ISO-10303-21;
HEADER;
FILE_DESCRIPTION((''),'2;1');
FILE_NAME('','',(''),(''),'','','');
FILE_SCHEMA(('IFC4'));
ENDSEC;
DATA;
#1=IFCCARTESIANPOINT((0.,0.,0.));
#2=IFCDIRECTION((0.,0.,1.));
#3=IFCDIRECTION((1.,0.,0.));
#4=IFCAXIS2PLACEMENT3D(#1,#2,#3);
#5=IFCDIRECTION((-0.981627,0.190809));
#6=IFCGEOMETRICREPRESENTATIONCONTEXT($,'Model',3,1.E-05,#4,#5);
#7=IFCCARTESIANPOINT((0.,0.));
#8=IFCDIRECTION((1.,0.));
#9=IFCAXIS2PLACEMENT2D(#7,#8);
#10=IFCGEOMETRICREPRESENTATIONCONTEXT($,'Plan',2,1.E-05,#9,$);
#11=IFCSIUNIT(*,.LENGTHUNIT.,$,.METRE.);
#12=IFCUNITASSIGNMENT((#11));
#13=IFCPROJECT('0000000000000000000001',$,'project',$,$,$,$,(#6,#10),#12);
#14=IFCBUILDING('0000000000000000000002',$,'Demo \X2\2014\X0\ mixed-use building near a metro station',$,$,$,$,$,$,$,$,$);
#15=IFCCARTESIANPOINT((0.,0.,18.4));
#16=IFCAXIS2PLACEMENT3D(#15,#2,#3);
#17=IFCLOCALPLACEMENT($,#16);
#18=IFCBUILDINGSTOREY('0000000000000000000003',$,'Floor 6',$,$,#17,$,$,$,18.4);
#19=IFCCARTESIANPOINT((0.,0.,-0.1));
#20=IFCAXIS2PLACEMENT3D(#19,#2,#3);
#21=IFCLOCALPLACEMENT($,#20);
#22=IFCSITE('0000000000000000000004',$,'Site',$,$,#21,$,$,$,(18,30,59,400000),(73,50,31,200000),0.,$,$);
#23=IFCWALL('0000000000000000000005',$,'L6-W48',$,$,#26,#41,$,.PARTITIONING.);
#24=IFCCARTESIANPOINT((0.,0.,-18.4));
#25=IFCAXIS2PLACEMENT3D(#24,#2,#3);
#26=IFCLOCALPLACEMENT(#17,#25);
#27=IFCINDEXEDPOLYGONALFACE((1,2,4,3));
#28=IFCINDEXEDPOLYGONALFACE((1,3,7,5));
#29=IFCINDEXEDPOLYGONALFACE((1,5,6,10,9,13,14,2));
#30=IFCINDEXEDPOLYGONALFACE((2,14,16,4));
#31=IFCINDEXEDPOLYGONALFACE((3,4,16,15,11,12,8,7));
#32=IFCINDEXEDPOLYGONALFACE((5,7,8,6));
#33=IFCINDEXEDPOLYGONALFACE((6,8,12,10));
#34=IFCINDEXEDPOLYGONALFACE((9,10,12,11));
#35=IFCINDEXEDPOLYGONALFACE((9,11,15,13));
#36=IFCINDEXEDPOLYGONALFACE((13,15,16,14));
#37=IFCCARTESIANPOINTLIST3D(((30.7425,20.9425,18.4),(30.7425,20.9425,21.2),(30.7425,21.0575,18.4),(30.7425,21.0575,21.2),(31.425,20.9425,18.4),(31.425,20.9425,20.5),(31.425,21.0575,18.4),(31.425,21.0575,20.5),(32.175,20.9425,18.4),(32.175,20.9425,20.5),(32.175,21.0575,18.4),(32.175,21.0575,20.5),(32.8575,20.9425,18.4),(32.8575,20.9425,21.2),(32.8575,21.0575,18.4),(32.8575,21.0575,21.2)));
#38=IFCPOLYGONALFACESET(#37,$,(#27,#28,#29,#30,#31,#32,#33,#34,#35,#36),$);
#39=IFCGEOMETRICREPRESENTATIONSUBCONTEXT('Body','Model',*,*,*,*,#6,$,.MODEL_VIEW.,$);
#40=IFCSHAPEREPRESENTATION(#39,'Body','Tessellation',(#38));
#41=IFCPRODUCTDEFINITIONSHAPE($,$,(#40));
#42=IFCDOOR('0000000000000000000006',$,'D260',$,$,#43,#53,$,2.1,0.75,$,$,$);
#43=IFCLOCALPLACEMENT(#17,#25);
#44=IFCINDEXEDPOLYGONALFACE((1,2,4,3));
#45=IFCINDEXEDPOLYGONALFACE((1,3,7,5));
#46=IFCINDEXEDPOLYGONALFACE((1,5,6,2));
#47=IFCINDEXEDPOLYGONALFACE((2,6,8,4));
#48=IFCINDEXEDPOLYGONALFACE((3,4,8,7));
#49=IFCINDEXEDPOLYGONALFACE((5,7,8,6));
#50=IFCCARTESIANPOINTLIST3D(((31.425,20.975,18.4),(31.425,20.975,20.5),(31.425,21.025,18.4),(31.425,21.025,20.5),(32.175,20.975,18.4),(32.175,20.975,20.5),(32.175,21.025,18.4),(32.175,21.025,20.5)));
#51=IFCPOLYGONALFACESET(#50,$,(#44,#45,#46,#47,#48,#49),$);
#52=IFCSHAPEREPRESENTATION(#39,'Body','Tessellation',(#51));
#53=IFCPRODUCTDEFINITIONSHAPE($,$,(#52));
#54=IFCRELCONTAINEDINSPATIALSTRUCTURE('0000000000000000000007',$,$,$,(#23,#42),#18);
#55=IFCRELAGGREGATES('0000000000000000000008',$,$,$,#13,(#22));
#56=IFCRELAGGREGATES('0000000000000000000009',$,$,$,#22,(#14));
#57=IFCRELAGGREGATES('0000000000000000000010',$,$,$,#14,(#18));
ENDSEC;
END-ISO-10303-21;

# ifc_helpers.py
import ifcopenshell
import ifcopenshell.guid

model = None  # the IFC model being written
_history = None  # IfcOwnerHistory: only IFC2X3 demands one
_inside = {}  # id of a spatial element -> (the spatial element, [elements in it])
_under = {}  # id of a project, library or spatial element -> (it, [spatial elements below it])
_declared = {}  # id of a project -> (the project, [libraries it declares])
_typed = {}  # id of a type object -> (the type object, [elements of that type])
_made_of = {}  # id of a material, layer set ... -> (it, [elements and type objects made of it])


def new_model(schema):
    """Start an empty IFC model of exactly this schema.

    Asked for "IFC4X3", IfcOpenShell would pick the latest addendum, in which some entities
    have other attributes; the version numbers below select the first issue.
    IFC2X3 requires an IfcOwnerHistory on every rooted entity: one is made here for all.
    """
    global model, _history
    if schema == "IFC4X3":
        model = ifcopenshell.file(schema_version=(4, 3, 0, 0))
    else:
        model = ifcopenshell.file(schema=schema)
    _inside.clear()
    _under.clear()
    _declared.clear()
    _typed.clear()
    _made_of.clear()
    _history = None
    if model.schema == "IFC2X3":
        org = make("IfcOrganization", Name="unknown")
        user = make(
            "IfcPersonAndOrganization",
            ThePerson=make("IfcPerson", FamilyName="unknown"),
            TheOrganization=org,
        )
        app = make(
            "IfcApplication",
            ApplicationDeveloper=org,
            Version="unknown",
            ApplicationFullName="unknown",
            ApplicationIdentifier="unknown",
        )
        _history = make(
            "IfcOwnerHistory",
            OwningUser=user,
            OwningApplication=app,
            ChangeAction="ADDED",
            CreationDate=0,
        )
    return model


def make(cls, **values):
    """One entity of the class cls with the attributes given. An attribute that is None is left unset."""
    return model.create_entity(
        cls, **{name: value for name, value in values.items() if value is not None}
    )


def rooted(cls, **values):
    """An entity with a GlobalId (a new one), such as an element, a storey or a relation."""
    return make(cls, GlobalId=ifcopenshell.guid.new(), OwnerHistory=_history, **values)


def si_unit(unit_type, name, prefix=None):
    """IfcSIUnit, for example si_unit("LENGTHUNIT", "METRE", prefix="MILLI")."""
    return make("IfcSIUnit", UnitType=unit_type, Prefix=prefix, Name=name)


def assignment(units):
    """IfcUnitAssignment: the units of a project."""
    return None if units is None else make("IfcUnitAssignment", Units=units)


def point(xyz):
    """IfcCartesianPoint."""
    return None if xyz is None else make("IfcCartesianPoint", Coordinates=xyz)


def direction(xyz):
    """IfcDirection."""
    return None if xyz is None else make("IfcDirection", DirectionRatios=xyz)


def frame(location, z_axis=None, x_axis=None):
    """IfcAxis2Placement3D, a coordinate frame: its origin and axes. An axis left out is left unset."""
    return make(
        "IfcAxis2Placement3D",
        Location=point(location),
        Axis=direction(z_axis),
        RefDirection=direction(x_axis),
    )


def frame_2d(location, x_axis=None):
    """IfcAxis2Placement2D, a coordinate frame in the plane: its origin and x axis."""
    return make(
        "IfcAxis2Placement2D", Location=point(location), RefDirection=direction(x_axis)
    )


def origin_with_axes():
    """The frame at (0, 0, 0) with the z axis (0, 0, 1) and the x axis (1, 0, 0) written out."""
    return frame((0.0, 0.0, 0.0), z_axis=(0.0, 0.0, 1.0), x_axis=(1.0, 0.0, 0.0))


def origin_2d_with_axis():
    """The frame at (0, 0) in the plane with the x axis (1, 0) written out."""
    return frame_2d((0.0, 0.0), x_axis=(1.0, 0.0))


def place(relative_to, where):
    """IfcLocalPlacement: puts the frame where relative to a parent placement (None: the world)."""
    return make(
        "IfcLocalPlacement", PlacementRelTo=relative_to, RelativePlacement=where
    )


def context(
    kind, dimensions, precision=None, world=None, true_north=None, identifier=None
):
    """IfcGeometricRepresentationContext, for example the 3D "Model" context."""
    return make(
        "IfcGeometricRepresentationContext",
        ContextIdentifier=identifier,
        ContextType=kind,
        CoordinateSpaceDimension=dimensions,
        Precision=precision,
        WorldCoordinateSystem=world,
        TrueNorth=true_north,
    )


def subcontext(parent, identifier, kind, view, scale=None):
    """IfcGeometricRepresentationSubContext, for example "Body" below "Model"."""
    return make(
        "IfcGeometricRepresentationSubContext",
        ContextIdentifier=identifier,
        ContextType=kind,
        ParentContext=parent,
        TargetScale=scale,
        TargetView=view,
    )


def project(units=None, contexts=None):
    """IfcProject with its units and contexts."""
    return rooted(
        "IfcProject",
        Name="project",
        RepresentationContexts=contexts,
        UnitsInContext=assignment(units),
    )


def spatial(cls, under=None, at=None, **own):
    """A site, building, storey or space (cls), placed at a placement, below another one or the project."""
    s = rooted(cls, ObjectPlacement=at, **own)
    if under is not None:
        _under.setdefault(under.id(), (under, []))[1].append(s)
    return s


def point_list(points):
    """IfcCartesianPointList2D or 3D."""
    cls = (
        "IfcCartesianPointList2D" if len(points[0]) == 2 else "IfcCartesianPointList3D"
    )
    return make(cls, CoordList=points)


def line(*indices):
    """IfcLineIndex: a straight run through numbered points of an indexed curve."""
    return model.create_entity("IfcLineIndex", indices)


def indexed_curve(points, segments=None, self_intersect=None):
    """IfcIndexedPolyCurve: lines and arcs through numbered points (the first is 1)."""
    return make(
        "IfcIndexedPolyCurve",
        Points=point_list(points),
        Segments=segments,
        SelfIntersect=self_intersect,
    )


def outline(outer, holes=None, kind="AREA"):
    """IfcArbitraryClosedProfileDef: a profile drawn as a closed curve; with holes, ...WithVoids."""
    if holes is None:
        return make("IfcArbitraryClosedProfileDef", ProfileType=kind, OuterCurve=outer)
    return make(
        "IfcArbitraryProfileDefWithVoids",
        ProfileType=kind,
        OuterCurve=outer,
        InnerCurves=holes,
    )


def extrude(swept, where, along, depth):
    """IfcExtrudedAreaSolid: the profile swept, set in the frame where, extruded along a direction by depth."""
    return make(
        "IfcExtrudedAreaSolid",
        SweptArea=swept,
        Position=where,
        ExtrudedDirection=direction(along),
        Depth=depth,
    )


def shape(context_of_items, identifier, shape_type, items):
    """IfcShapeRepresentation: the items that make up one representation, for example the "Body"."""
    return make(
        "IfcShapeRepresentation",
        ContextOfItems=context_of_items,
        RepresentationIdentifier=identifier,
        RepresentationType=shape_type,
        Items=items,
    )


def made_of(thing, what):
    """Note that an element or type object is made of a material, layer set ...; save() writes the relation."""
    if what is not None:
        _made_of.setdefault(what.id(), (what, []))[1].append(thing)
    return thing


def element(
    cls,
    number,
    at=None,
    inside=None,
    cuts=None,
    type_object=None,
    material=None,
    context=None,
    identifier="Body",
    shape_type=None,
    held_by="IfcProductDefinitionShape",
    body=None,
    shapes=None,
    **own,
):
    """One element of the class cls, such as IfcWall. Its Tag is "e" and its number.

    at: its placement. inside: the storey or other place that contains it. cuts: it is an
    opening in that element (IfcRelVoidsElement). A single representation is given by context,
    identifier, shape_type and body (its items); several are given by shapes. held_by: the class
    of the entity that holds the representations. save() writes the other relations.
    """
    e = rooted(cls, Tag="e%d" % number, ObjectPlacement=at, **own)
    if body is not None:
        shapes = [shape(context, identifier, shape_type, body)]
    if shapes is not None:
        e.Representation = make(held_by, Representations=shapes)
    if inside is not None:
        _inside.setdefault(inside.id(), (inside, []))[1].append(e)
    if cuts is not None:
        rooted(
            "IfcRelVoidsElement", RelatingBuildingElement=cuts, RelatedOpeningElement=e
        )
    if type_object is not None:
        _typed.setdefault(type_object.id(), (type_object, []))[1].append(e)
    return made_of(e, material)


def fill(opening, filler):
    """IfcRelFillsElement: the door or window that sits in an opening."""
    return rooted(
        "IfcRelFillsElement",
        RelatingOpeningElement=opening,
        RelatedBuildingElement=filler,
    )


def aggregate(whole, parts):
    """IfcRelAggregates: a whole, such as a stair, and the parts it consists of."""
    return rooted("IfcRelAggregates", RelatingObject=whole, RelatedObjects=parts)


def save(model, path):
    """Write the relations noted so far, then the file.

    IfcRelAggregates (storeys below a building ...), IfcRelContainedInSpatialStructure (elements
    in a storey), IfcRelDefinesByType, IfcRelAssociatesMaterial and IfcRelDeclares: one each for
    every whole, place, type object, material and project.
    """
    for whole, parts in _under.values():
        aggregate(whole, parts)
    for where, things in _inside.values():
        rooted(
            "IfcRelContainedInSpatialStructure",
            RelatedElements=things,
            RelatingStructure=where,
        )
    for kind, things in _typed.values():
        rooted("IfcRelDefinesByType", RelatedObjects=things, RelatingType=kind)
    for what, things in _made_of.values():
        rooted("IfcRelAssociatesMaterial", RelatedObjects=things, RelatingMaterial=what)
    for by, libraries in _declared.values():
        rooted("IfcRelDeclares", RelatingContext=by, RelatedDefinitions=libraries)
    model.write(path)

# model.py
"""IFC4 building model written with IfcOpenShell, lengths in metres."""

from ifc_helpers import new_model, si_unit, direction, frame, origin_with_axes, origin_2d_with_axis, place, context, subcontext, project, spatial, line, indexed_curve, outline, extrude, element, fill, save


model = new_model("IFC4")

# Units and contexts
model_context = context("Model", 3, precision=1e-05, world=origin_with_axes(), true_north=direction((-0.981627, 0.190809)))
plan_context = context("Plan", 2, precision=1e-05, world=origin_2d_with_axis())
body_context = subcontext(model_context, "Body", "Model", "MODEL_VIEW")
ifc_project = project(units=[si_unit("LENGTHUNIT", "METRE")], contexts=[model_context, plan_context])

# Site, building, storey
site_placement = place(None, frame((0.0, 0.0, -0.1), z_axis=(0.0, 0.0, 1.0), x_axis=(1.0, 0.0, 0.0)))
site = spatial("IfcSite", under=ifc_project, at=site_placement, Name="Site", RefLatitude=(18, 30, 59, 400000), RefLongitude=(73, 50, 31, 200000), RefElevation=0.0)
building = spatial("IfcBuilding", under=site, Name="Demo — mixed-use building near a metro station")
storey_placement = place(None, frame((0.0, 0.0, 18.4), z_axis=(0.0, 0.0, 1.0), x_axis=(1.0, 0.0, 0.0)))
storey = spatial("IfcBuildingStorey", under=building, at=storey_placement, Name="Floor 6", Elevation=18.4)

# Wall, opening, door
wall_1_placement = place(storey_placement, frame((0.0, 0.0, -18.4), z_axis=(0.0, 0.0, 1.0), x_axis=(1.0, 0.0, 0.0)))
wall_1 = element("IfcWall", 1, at=wall_1_placement, inside=storey, Name="L6-W48", PredefinedType="PARTITIONING", context=body_context, shape_type="SweptSolid", body=[
    extrude(outline(indexed_curve([(32.8575, 20.9425), (30.7425, 20.9425), (30.7425, 21.0575), (32.8575, 21.0575)], segments=[line(1, 2, 3, 4, 1)])), frame((0.0, 0.0, 18.4), z_axis=(0.0, 0.0, 1.0), x_axis=(1.0, 0.0, 0.0)), (0.0, 0.0, 1.0), 2.8),
])
opening_1_placement = place(wall_1_placement, origin_with_axes())
opening_1 = element("IfcOpeningElement", 2, at=opening_1_placement, cuts=wall_1, context=body_context, shape_type="SweptSolid", body=[
    extrude(outline(indexed_curve([(32.175, 20.8925), (31.425, 20.8925), (31.425, 21.1075), (32.175, 21.1075)], segments=[line(1, 2, 3, 4, 1)])), frame((0.0, 0.0, 18.4), z_axis=(0.0, 0.0, 1.0), x_axis=(1.0, 0.0, 0.0)), (0.0, 0.0, 1.0), 2.1),
])
door_1_placement = place(storey_placement, frame((0.0, 0.0, -18.4), z_axis=(0.0, 0.0, 1.0), x_axis=(1.0, 0.0, 0.0)))
door_1 = element("IfcDoor", 3, at=door_1_placement, inside=storey, Name="D260", OverallHeight=2.1, OverallWidth=0.75, context=body_context, shape_type="SweptSolid", body=[
    extrude(outline(indexed_curve([(32.175, 20.975), (31.425, 20.975), (31.425, 21.025), (32.175, 21.025)], segments=[line(1, 2, 3, 4, 1)])), frame((0.0, 0.0, 18.4), z_axis=(0.0, 0.0, 1.0), x_axis=(1.0, 0.0, 0.0)), (0.0, 0.0, 1.0), 2.1),
])
fill(opening_1, door_1)

save(model, "model.ifc")
